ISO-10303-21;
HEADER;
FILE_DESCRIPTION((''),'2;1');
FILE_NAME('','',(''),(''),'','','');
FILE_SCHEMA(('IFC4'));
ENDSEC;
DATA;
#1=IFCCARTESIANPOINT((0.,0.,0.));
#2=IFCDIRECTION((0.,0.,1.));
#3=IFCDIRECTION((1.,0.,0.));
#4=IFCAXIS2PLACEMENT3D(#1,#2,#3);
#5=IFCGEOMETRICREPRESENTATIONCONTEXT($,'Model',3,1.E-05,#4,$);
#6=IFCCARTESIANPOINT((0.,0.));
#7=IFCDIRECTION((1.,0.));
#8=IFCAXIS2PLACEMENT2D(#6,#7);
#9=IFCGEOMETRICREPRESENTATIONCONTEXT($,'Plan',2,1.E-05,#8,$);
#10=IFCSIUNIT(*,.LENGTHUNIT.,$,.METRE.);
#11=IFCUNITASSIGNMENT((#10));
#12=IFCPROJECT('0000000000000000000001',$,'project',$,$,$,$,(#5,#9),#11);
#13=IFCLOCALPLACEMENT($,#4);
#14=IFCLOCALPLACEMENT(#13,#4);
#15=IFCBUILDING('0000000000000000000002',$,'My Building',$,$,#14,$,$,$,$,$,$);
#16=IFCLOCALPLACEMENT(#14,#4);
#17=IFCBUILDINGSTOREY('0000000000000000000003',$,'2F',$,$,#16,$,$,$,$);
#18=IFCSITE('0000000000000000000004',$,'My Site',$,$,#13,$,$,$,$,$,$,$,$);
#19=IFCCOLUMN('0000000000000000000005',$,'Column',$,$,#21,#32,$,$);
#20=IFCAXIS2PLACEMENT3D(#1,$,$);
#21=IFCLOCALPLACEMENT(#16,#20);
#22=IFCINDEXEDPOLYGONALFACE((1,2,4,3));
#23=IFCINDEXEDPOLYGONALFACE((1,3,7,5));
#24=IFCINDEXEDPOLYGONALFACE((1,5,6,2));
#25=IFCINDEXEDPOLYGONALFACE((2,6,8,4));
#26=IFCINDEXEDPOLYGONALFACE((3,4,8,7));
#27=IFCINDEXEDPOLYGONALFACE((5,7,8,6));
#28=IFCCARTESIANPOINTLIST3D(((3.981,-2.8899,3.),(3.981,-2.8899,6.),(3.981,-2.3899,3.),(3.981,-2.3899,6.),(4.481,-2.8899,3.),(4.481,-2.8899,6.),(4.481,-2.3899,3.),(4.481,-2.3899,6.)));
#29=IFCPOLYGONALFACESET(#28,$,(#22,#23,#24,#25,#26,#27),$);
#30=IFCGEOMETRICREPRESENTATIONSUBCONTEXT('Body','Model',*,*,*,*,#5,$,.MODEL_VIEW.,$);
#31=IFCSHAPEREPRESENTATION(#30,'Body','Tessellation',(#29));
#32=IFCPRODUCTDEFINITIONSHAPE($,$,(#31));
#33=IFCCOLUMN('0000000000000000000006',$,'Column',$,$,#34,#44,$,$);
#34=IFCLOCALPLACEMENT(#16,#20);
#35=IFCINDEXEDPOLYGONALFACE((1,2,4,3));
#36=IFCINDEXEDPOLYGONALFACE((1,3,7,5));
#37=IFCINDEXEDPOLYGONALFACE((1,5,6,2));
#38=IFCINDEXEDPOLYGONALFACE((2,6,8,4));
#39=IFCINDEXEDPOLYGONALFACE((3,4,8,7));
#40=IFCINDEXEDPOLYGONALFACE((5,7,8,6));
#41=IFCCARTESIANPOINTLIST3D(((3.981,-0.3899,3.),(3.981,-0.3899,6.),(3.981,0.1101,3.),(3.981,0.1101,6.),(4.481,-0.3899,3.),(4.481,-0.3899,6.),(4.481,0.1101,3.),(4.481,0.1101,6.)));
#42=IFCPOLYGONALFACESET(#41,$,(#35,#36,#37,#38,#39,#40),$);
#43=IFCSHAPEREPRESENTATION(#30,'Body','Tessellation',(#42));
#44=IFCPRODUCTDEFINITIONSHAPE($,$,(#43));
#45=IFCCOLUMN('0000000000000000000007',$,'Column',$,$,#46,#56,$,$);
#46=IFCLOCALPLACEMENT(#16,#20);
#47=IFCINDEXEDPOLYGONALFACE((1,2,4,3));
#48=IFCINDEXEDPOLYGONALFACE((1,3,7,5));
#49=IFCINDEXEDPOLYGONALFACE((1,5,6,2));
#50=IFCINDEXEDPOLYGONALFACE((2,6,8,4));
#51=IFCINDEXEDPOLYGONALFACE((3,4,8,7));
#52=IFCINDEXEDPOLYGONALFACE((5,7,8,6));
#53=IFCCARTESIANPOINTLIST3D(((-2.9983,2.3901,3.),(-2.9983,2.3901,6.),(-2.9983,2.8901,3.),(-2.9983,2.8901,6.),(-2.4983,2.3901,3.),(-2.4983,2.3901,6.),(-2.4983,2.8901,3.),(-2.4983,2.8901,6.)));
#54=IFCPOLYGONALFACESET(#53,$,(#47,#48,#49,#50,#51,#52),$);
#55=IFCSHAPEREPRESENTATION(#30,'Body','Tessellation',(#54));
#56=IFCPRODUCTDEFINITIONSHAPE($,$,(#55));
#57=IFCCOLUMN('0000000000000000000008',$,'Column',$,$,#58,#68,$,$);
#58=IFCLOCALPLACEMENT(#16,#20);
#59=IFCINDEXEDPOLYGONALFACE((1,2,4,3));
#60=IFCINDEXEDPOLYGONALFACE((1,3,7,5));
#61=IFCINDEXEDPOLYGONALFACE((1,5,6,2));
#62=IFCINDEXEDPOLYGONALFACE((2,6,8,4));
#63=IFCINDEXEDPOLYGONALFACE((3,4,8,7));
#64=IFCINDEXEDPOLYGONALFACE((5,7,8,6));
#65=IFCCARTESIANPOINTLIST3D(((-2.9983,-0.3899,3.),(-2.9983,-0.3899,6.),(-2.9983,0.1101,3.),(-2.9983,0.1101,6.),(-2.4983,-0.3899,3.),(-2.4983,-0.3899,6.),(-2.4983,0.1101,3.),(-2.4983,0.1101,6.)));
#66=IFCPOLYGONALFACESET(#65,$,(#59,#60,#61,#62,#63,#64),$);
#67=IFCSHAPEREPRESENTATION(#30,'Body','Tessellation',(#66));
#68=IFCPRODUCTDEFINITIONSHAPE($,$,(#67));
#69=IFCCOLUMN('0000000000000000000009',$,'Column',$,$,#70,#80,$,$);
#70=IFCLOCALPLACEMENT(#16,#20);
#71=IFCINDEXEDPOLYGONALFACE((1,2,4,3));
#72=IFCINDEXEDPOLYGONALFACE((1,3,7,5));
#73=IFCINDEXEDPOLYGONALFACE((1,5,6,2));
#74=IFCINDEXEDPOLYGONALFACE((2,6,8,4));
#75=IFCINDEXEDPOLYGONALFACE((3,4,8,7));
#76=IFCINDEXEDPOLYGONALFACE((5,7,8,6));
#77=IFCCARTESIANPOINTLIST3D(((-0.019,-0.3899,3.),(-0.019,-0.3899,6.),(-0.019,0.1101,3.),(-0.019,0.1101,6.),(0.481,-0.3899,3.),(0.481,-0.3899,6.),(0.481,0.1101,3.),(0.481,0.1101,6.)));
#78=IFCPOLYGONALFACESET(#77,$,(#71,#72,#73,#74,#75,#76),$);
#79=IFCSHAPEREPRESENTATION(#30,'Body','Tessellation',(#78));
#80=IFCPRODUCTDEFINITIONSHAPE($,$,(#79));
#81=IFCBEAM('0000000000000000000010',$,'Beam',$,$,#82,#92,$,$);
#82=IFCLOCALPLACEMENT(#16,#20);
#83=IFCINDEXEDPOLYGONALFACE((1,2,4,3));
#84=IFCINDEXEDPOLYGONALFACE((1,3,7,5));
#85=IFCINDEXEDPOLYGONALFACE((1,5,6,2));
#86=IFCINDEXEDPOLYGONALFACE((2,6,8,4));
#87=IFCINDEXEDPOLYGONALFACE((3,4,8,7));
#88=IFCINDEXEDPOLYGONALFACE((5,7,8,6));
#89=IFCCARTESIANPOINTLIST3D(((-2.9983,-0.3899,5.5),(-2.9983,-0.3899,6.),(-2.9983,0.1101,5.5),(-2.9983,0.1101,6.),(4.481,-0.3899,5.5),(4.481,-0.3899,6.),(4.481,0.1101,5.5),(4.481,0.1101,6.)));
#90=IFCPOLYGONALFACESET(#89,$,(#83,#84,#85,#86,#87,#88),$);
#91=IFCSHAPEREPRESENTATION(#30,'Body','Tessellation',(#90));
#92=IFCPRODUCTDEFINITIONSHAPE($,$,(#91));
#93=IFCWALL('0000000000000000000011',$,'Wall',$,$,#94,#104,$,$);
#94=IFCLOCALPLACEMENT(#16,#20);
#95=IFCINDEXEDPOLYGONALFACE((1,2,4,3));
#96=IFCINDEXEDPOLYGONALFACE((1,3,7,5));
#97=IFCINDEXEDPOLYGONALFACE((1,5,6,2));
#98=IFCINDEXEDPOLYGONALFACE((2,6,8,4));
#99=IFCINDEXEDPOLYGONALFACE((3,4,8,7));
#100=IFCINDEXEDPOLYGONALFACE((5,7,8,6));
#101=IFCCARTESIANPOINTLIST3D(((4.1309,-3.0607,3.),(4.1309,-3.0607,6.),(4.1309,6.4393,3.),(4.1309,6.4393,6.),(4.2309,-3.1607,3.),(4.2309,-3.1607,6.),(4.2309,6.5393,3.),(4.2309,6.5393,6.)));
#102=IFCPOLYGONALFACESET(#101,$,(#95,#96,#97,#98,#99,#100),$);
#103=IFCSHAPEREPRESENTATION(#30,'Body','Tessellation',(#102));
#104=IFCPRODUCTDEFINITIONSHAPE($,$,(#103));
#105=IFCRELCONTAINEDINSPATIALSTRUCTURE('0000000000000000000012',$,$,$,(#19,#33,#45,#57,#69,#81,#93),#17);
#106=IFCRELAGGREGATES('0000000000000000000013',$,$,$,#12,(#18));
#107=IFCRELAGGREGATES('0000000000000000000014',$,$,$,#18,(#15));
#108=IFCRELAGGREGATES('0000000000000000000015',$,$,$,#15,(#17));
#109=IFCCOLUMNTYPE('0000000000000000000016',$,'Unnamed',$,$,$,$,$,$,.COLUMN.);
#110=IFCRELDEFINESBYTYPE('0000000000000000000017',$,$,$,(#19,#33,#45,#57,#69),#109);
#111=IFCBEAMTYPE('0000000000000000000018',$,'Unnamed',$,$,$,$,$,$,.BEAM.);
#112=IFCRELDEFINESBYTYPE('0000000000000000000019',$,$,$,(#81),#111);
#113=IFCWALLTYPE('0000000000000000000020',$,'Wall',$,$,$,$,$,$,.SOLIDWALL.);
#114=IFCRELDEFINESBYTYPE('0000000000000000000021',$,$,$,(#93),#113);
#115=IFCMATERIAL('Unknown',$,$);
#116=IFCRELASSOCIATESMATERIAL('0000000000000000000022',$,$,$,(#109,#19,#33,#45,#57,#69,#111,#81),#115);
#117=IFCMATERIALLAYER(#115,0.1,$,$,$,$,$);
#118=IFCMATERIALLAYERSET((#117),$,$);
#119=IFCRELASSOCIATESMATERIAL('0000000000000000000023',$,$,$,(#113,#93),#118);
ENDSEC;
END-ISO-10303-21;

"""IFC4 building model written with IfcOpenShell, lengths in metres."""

from ifc_helpers import new_model, si_unit, frame, origin_with_axes, origin_2d_with_axis, place, context, subcontext, project, spatial, line, indexed_curve, rectangle, outline, extrude, material, layer, layer_set, layer_usage, material_profile, profile_set, profile_usage, type_object, element, save


model = new_model("IFC4")

# Units and contexts
model_context = context("Model", 3, precision=1e-05, world=origin_with_axes())
plan_context = context("Plan", 2, precision=1e-05, world=origin_2d_with_axis())
body_context_1 = subcontext(model_context, "Body", "Model", "MODEL_VIEW")
ifc_project = project(units=[si_unit("LENGTHUNIT", "METRE")], contexts=[model_context, plan_context])

# Site, building, storey
site_placement = place(None, origin_with_axes())
site = spatial("IfcSite", under=ifc_project, at=site_placement, Name="My Site")
building_placement = place(site_placement, origin_with_axes())
building = spatial("IfcBuilding", under=site, at=building_placement, Name="My Building")
storey_placement = place(building_placement, origin_with_axes())
storey = spatial("IfcBuildingStorey", under=building, at=storey_placement, Name="2F")

# Columns
ifc_material = material(Name="Unknown")
ifc_material_profile_1 = material_profile(ifc_material, rectangle(XDim=0.5, YDim=0.5))
ifc_profile_set_1 = profile_set([ifc_material_profile_1])
ifc_profile_usage_1 = profile_usage(ifc_profile_set_1, cardinal=7)
column_type = type_object("IfcColumnType", Name="Unnamed", PredefinedType="COLUMN", material=ifc_profile_set_1)
column_1_placement = place(storey_placement, frame((4.481, -2.3899, 3.0), z_axis=(0.0, 0.0, 1.0), x_axis=(1.0, 0.0, 0.0)))
element("IfcColumn", 1, at=column_1_placement, inside=storey, type_object=column_type, material=ifc_profile_usage_1, Name="Column", context=body_context_1, shape_type="SweptSolid", body=[
    extrude(rectangle(XDim=0.5, YDim=0.5), frame((-0.25, -0.25, 0.0), z_axis=(0.0, 0.0, 1.0), x_axis=(1.0, 0.0, 0.0)), (0.0, 0.0, 1.0), 3.0),
])
ifc_profile_usage_2 = profile_usage(ifc_profile_set_1, cardinal=7)
column_2_placement = place(storey_placement, frame((4.481, 0.1101, 3.0), z_axis=(0.0, 0.0, 1.0), x_axis=(1.0, 0.0, 0.0)))
element("IfcColumn", 2, at=column_2_placement, inside=storey, type_object=column_type, material=ifc_profile_usage_2, Name="Column", context=body_context_1, shape_type="SweptSolid", body=[
    extrude(rectangle(XDim=0.5, YDim=0.5), frame((-0.25, -0.25, 0.0), z_axis=(0.0, 0.0, 1.0), x_axis=(1.0, 0.0, 0.0)), (0.0, 0.0, 1.0), 3.0),
])
ifc_profile_usage_3 = profile_usage(ifc_profile_set_1, cardinal=7)
column_3_placement = place(storey_placement, frame((-2.4983, 2.8901, 3.0), z_axis=(0.0, 0.0, 1.0), x_axis=(1.0, 0.0, 0.0)))
element("IfcColumn", 3, at=column_3_placement, inside=storey, type_object=column_type, material=ifc_profile_usage_3, Name="Column", context=body_context_1, shape_type="SweptSolid", body=[
    extrude(rectangle(XDim=0.5, YDim=0.5), frame((-0.25, -0.25, 0.0), z_axis=(0.0, 0.0, 1.0), x_axis=(1.0, 0.0, 0.0)), (0.0, 0.0, 1.0), 3.0),
])
ifc_profile_usage_4 = profile_usage(ifc_profile_set_1, cardinal=7)
column_4_placement = place(storey_placement, frame((-2.4983, 0.1101, 3.0), z_axis=(0.0, 0.0, 1.0), x_axis=(1.0, 0.0, 0.0)))
element("IfcColumn", 4, at=column_4_placement, inside=storey, type_object=column_type, material=ifc_profile_usage_4, Name="Column", context=body_context_1, shape_type="SweptSolid", body=[
    extrude(rectangle(XDim=0.5, YDim=0.5), frame((-0.25, -0.25, 0.0), z_axis=(0.0, 0.0, 1.0), x_axis=(1.0, 0.0, 0.0)), (0.0, 0.0, 1.0), 3.0),
])
ifc_profile_usage_5 = profile_usage(ifc_profile_set_1, cardinal=7)
column_5_placement = place(storey_placement, frame((0.481, 0.1101, 3.0), z_axis=(0.0, 0.0, 1.0), x_axis=(1.0, 0.0, 0.0)))
element("IfcColumn", 5, at=column_5_placement, inside=storey, type_object=column_type, material=ifc_profile_usage_5, Name="Column", context=body_context_1, shape_type="SweptSolid", body=[
    extrude(rectangle(XDim=0.5, YDim=0.5), frame((-0.25, -0.25, 0.0), z_axis=(0.0, 0.0, 1.0), x_axis=(1.0, 0.0, 0.0)), (0.0, 0.0, 1.0), 3.0),
])

# Beam
ifc_material_profile_2 = material_profile(ifc_material, rectangle(XDim=0.5, YDim=0.5))
ifc_profile_set_2 = profile_set([ifc_material_profile_2])
ifc_profile_usage_6 = profile_usage(ifc_profile_set_2, cardinal=7)
beam_type = type_object("IfcBeamType", Name="Unnamed", PredefinedType="BEAM", material=ifc_profile_set_2)
beam_placement = place(storey_placement, frame((-2.9983, 0.1101, 6.0), z_axis=(1.0, 0.0, 0.0), x_axis=(0.0, 1.0, 0.0)))
element("IfcBeam", 6, at=beam_placement, inside=storey, type_object=beam_type, material=ifc_profile_usage_6, Name="Beam", context=body_context_1, shape_type="SweptSolid", body=[
    extrude(rectangle(XDim=0.5, YDim=0.5), frame((-0.25, -0.25, 0.0), z_axis=(0.0, 0.0, 1.0), x_axis=(1.0, 0.0, 0.0)), (0.0, 0.0, 1.0), 7.4793),
])

# Wall
ifc_layer = layer(ifc_material, 0.1)
ifc_layer_set = layer_set([ifc_layer])
ifc_layer_usage_1 = layer_usage(ifc_layer_set, "AXIS2", "POSITIVE", 0.0)
wall_type = type_object("IfcWallType", Name="Wall", PredefinedType="SOLIDWALL", material=ifc_layer_set)
wall_1_placement = place(storey_placement, frame((4.2309, -3.1607, 3.0), z_axis=(0.0, 0.0, 1.0), x_axis=(0.0, 1.0, 0.0)))
element("IfcWall", 7, at=wall_1_placement, inside=storey, type_object=wall_type, material=ifc_layer_usage_1, Name="Wall", context=body_context_1, shape_type="SweptSolid", body=[
    extrude(outline(indexed_curve([(0.0, 0.0), (0.1, 0.1), (9.6, 0.1), (9.7, 0.0)], segments=[line(1, 2, 3, 4, 1)])), origin_with_axes(), (0.0, 0.0, 1.0), 3.0),
])

save(model, "model.ifc")
